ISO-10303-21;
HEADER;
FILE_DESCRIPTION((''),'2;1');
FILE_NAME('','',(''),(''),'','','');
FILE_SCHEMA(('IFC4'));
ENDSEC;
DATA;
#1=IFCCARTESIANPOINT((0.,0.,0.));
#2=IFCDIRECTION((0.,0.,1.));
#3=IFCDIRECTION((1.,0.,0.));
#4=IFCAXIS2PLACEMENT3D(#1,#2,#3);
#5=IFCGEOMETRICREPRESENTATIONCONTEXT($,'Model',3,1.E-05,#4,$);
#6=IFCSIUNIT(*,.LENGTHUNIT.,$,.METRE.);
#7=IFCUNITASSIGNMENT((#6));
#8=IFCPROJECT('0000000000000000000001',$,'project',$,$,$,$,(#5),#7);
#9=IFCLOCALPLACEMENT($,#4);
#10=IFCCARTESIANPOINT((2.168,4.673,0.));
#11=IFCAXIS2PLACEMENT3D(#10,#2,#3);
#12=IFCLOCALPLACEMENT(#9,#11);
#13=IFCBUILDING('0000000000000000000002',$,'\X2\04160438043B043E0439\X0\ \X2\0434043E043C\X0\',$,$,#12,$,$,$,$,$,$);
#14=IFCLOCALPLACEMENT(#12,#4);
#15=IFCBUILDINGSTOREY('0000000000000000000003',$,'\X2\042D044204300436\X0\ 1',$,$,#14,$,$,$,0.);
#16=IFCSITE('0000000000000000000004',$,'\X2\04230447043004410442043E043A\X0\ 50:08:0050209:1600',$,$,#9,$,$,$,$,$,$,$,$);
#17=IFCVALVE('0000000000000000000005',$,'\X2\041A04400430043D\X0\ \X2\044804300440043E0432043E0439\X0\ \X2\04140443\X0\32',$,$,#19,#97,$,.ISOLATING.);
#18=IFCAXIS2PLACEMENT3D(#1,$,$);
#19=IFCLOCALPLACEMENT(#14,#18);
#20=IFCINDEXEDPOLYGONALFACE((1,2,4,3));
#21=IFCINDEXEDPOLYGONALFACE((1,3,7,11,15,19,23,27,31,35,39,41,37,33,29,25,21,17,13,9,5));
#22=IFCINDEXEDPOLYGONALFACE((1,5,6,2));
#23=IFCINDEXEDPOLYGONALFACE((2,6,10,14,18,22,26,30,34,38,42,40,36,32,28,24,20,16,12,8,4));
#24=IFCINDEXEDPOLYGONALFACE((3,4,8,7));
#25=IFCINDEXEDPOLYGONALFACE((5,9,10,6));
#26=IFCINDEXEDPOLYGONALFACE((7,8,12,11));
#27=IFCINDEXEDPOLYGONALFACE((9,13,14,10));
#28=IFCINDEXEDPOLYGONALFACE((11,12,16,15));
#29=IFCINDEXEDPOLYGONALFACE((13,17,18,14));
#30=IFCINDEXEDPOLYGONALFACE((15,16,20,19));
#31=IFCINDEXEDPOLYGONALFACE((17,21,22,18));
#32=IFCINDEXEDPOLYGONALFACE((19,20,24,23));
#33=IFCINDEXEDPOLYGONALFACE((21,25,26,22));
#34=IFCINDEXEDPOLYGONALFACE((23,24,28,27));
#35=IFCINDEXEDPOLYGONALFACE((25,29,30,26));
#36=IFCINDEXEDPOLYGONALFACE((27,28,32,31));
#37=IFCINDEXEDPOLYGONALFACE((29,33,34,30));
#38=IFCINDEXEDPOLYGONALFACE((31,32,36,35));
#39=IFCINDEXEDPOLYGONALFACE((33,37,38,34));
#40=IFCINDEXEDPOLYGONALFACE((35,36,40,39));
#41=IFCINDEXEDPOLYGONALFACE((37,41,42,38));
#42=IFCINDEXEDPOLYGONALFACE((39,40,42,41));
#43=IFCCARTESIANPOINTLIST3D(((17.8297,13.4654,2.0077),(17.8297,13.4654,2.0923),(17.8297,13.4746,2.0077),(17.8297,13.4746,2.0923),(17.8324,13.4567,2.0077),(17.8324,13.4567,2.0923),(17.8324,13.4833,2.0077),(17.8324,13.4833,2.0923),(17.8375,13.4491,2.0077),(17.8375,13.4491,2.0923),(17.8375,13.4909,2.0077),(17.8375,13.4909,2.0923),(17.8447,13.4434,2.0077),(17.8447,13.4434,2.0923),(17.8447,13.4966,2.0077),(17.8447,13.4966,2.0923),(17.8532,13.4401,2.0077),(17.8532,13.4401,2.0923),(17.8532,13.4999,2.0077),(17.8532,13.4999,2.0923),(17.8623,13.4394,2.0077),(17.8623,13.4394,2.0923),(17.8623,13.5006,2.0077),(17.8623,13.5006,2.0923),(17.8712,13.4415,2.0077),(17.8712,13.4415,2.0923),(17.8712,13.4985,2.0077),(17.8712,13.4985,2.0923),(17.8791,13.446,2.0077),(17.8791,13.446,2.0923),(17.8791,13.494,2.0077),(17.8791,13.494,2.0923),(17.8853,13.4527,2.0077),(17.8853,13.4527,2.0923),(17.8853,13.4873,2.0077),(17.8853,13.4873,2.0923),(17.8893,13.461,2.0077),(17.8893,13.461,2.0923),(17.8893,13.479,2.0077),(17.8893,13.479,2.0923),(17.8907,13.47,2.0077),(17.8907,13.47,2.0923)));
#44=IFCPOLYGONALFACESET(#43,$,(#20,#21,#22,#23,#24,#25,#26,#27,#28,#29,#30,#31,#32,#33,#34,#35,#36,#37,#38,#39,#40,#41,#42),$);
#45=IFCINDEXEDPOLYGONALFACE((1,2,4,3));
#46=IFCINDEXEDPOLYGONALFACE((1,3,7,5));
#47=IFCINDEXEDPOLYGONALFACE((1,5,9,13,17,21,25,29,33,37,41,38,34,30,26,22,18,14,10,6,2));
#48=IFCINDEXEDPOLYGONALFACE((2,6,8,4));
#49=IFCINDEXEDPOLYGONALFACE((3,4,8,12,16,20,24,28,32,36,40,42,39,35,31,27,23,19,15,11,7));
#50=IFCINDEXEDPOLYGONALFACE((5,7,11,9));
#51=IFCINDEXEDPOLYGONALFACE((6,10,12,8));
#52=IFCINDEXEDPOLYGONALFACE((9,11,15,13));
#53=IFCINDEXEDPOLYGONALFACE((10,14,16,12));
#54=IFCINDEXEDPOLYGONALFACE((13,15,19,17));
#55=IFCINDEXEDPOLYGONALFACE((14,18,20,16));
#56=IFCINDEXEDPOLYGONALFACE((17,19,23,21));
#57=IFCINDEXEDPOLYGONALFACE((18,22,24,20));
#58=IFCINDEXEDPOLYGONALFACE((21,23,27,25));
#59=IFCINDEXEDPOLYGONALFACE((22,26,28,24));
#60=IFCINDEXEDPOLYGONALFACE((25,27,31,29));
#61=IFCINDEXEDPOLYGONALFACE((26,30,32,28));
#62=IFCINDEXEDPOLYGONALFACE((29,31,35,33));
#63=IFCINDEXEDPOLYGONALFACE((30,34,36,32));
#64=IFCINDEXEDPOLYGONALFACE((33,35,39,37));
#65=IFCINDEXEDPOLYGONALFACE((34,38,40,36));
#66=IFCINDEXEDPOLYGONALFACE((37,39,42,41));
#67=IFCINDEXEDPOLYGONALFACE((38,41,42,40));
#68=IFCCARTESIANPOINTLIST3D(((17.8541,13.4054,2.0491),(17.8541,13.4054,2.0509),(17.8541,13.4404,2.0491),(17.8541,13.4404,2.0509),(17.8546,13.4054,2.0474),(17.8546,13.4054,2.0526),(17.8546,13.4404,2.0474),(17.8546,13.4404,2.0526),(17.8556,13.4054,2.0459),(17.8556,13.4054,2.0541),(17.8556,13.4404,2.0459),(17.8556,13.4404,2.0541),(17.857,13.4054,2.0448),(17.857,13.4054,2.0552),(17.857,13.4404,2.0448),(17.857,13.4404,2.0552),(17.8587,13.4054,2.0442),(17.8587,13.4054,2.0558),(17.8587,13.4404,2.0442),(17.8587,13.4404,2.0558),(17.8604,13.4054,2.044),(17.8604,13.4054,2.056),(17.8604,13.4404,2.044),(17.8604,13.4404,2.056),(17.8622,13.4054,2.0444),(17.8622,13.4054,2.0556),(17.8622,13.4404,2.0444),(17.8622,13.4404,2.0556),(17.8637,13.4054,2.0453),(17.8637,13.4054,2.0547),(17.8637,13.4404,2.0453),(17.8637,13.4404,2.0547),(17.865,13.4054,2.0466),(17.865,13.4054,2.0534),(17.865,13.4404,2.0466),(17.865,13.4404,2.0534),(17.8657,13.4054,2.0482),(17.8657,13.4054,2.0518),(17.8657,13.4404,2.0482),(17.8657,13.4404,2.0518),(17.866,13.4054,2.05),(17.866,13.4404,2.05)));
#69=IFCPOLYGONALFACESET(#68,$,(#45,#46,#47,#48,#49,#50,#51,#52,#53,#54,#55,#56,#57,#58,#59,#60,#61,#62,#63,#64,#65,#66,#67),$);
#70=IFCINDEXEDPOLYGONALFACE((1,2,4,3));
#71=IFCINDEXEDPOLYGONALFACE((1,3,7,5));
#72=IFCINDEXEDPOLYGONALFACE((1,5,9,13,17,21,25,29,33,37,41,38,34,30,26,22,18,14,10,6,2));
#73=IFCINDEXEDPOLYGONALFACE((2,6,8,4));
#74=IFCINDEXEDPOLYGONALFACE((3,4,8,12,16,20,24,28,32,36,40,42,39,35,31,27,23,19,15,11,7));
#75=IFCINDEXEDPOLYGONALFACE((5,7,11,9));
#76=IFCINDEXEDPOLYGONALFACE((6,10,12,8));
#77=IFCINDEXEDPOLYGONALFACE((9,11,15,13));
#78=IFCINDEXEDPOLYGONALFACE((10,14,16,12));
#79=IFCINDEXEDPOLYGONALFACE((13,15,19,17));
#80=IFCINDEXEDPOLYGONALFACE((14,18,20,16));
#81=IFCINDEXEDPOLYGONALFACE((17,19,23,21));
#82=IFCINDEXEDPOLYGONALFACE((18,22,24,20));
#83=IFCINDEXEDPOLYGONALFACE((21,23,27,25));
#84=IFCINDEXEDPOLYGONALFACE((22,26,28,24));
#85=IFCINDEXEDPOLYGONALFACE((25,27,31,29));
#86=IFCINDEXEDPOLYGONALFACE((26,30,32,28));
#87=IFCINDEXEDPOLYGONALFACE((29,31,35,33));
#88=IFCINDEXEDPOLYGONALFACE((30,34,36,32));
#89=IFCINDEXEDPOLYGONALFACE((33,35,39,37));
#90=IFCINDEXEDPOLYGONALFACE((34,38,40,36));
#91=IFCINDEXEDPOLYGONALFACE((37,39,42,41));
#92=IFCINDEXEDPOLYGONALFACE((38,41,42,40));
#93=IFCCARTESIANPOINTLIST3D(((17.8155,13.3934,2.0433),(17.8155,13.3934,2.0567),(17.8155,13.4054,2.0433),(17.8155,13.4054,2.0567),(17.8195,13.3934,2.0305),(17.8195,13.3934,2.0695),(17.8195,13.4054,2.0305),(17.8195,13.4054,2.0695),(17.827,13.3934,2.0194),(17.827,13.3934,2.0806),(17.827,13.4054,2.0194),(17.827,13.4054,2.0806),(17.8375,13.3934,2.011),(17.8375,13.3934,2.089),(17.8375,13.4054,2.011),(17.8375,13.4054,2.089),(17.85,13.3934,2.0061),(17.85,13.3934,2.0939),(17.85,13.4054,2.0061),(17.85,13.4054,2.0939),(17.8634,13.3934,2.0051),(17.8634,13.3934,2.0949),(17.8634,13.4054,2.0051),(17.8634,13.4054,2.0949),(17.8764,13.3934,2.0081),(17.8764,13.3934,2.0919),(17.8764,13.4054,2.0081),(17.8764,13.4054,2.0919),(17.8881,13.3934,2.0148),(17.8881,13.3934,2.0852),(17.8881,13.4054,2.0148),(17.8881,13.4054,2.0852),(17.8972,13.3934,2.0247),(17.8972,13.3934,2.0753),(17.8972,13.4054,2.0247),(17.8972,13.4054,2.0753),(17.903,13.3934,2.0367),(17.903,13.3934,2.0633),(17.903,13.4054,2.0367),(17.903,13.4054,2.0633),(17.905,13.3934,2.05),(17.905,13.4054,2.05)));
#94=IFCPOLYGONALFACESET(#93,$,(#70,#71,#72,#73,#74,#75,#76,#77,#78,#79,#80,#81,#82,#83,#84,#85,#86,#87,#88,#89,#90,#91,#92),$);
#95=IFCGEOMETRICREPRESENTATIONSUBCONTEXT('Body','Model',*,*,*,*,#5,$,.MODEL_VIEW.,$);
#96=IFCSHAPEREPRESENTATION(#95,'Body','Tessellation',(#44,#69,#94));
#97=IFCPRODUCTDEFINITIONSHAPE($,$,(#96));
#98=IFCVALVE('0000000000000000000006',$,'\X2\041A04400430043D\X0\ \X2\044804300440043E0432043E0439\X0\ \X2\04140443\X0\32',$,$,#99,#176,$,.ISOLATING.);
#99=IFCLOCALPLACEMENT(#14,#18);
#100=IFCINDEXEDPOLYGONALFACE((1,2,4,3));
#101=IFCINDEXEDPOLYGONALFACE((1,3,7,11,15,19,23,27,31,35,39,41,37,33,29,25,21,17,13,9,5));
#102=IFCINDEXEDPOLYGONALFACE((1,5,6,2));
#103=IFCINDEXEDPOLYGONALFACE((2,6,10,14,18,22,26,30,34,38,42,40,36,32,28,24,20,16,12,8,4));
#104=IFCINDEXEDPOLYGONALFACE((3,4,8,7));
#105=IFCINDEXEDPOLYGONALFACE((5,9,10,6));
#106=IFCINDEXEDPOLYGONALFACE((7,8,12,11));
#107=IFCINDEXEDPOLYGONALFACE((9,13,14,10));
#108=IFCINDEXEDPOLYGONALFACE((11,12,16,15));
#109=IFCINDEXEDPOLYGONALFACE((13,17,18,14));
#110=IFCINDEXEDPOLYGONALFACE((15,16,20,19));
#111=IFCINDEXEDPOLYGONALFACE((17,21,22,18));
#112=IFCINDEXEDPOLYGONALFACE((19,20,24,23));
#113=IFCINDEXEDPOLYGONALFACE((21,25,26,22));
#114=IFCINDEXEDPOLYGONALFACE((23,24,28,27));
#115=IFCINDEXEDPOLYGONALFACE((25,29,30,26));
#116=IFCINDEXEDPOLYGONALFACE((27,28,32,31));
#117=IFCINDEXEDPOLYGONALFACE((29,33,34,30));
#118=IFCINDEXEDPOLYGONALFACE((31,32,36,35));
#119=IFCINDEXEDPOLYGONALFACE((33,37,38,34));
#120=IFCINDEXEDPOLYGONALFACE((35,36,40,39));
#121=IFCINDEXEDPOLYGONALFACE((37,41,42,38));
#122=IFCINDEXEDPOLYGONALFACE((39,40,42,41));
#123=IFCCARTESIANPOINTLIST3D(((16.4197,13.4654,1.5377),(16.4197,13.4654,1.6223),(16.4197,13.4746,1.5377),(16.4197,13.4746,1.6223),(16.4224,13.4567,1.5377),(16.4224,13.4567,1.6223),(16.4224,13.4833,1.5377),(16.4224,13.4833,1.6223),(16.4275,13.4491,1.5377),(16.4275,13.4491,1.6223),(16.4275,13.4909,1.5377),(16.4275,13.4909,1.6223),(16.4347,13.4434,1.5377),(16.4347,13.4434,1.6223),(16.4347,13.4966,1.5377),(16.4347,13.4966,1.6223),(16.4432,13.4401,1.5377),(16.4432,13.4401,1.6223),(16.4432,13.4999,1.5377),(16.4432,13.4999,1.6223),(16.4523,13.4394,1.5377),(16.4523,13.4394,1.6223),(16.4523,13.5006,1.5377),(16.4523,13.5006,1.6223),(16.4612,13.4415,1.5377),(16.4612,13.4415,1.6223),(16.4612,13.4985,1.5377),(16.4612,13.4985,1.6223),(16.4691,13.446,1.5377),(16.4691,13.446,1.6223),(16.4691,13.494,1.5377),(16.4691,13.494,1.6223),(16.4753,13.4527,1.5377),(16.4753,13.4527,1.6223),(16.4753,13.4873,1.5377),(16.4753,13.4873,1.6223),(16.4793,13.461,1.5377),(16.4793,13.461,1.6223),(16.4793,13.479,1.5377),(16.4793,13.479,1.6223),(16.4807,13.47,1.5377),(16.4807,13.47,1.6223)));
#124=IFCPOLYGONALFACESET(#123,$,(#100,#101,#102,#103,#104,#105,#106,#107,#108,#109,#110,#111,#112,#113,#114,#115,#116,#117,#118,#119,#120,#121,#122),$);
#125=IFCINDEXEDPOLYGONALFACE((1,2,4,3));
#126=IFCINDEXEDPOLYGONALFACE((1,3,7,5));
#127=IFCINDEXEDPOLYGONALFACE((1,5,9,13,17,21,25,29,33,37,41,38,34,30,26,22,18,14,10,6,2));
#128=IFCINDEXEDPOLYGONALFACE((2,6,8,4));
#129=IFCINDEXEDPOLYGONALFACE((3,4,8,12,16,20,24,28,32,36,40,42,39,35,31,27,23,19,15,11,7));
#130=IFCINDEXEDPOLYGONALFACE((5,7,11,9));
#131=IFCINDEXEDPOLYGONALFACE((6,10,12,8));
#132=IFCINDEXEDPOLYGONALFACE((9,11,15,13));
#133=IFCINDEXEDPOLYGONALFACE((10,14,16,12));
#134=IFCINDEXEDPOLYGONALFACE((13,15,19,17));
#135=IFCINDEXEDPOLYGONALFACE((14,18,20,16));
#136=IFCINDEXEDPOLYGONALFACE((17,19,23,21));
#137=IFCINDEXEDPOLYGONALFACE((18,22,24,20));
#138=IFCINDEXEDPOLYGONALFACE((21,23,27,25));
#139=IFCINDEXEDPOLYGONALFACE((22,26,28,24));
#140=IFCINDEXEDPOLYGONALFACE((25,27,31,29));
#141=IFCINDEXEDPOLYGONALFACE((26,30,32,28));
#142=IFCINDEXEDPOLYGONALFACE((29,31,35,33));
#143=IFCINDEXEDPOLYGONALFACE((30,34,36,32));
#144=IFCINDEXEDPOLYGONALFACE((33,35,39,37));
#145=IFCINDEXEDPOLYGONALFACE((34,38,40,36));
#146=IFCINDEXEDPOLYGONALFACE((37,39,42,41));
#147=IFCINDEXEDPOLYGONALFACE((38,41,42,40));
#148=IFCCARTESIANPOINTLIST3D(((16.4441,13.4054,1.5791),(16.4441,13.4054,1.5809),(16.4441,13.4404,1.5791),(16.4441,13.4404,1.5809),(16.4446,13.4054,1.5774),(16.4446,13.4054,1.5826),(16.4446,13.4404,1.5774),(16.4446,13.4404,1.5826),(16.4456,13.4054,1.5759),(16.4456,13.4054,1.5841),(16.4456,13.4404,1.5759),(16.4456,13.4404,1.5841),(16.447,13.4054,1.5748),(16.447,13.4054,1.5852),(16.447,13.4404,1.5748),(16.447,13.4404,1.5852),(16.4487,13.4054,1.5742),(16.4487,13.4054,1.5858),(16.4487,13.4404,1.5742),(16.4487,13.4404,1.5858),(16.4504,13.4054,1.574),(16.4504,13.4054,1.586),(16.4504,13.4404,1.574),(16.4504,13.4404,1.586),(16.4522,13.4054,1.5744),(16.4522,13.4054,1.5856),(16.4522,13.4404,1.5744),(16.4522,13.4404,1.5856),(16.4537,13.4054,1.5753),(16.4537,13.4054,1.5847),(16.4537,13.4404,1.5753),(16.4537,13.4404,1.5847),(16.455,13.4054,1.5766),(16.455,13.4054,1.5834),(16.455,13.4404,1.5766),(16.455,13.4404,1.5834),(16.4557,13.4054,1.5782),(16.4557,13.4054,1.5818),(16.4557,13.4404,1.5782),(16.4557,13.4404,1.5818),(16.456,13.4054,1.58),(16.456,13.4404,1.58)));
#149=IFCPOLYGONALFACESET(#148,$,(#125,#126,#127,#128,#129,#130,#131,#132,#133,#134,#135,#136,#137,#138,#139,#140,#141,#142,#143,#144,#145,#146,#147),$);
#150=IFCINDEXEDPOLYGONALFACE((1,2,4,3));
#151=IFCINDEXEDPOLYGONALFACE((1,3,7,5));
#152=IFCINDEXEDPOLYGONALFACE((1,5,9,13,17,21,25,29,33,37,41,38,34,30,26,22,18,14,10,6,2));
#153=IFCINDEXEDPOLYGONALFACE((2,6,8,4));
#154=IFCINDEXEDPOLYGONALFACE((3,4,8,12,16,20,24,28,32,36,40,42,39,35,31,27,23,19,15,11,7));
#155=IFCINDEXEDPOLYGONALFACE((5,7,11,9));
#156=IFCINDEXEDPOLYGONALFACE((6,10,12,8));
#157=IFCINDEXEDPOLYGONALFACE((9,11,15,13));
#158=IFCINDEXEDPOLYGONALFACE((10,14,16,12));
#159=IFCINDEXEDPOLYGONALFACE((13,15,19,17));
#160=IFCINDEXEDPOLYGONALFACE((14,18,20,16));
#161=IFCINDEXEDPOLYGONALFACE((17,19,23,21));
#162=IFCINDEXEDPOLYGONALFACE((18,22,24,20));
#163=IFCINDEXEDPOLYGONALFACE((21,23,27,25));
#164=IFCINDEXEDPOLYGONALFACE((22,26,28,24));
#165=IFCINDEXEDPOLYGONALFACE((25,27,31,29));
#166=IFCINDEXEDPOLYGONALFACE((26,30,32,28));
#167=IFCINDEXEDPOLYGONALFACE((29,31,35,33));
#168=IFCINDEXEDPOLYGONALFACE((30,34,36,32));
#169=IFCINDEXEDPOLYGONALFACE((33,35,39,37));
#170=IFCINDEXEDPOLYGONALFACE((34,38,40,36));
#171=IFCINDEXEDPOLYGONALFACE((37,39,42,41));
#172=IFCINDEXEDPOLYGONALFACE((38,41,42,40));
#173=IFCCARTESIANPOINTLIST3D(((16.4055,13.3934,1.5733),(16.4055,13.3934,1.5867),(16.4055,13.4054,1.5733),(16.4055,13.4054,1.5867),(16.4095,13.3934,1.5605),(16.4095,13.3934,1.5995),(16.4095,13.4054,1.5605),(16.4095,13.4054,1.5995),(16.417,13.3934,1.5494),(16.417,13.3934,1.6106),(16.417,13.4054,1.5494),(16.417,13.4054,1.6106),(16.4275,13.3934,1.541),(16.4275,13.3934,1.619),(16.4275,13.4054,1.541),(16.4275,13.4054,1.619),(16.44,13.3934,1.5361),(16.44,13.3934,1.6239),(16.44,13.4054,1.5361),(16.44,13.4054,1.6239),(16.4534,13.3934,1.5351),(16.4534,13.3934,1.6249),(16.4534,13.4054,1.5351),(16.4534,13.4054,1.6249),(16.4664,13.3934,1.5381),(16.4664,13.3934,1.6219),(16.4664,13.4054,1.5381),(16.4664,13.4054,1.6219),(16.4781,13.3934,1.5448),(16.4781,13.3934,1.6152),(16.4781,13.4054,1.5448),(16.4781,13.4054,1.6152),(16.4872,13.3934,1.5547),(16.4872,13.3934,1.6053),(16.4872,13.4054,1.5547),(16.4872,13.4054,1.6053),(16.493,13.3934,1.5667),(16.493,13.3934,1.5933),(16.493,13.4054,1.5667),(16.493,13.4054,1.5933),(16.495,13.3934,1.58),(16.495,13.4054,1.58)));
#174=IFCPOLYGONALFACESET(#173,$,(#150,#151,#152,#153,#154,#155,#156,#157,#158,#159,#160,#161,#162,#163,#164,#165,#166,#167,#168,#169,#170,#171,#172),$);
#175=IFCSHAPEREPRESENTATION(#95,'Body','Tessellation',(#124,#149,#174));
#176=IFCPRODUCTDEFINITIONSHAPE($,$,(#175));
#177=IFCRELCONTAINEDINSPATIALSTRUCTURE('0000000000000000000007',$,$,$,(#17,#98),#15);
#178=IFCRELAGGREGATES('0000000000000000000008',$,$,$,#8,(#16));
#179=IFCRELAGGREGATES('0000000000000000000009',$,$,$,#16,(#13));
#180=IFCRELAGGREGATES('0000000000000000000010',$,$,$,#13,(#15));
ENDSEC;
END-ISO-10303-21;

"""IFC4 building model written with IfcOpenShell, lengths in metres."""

from ifc_helpers import new_model, si_unit, frame, origin_with_axes, origin_2d, place, context, subcontext, project, spatial, circle, extrude, element, save


model = new_model("IFC4")

# Units and contexts
model_context = context("Model", 3, precision=1e-05, world=origin_with_axes())
body_context = subcontext(model_context, "Body", "Model", "MODEL_VIEW")
ifc_project = project(units=[si_unit("LENGTHUNIT", "METRE")], contexts=[model_context])

# Site, building, storey
site_placement = place(None, origin_with_axes())
site = spatial("IfcSite", under=ifc_project, at=site_placement, Name="Участок 50:08:0050209:1600")
building_placement = place(site_placement, frame((2.168, 4.673, 0.0), z_axis=(0.0, 0.0, 1.0), x_axis=(1.0, 0.0, 0.0)))
building = spatial("IfcBuilding", under=site, at=building_placement, Name="Жилой дом")
storey_placement = place(building_placement, origin_with_axes())
storey = spatial("IfcBuildingStorey", under=building, at=storey_placement, Name="Этаж 1", Elevation=0.0)

# Valves
valve_1_placement = place(storey_placement, origin_with_axes())
element("IfcValve", 1, at=valve_1_placement, inside=storey, Name="Кран шаровой Ду32", PredefinedType="ISOLATING", context=body_context, shape_type="SweptSolid", body=[
    extrude(circle(Radius=0.0307, at=origin_2d()), frame((17.86, 13.47, 2.0077), z_axis=(0.0, 0.0, 1.0), x_axis=(1.0, 0.0, 0.0)), (0.0, 0.0, 1.0), 0.0846),
    extrude(circle(Radius=0.006, at=origin_2d()), frame((17.86, 13.4404, 2.05), z_axis=(0.0, -1.0, 0.0), x_axis=(1.0, 0.0, 0.0)), (0.0, 0.0, 1.0), 0.035),
    extrude(circle(Radius=0.045, at=origin_2d()), frame((17.86, 13.4054, 2.05), z_axis=(0.0, -1.0, 0.0), x_axis=(1.0, 0.0, 0.0)), (0.0, 0.0, 1.0), 0.012),
])
valve_2_placement = place(storey_placement, origin_with_axes())
element("IfcValve", 2, at=valve_2_placement, inside=storey, Name="Кран шаровой Ду32", PredefinedType="ISOLATING", context=body_context, shape_type="SweptSolid", body=[
    extrude(circle(Radius=0.0307, at=origin_2d()), frame((16.45, 13.47, 1.5377), z_axis=(0.0, 0.0, 1.0), x_axis=(1.0, 0.0, 0.0)), (0.0, 0.0, 1.0), 0.0846),
    extrude(circle(Radius=0.006, at=origin_2d()), frame((16.45, 13.4404, 1.58), z_axis=(0.0, -1.0, 0.0), x_axis=(1.0, 0.0, 0.0)), (0.0, 0.0, 1.0), 0.035),
    extrude(circle(Radius=0.045, at=origin_2d()), frame((16.45, 13.4054, 1.58), z_axis=(0.0, -1.0, 0.0), x_axis=(1.0, 0.0, 0.0)), (0.0, 0.0, 1.0), 0.012),
])

save(model, "model.ifc")
